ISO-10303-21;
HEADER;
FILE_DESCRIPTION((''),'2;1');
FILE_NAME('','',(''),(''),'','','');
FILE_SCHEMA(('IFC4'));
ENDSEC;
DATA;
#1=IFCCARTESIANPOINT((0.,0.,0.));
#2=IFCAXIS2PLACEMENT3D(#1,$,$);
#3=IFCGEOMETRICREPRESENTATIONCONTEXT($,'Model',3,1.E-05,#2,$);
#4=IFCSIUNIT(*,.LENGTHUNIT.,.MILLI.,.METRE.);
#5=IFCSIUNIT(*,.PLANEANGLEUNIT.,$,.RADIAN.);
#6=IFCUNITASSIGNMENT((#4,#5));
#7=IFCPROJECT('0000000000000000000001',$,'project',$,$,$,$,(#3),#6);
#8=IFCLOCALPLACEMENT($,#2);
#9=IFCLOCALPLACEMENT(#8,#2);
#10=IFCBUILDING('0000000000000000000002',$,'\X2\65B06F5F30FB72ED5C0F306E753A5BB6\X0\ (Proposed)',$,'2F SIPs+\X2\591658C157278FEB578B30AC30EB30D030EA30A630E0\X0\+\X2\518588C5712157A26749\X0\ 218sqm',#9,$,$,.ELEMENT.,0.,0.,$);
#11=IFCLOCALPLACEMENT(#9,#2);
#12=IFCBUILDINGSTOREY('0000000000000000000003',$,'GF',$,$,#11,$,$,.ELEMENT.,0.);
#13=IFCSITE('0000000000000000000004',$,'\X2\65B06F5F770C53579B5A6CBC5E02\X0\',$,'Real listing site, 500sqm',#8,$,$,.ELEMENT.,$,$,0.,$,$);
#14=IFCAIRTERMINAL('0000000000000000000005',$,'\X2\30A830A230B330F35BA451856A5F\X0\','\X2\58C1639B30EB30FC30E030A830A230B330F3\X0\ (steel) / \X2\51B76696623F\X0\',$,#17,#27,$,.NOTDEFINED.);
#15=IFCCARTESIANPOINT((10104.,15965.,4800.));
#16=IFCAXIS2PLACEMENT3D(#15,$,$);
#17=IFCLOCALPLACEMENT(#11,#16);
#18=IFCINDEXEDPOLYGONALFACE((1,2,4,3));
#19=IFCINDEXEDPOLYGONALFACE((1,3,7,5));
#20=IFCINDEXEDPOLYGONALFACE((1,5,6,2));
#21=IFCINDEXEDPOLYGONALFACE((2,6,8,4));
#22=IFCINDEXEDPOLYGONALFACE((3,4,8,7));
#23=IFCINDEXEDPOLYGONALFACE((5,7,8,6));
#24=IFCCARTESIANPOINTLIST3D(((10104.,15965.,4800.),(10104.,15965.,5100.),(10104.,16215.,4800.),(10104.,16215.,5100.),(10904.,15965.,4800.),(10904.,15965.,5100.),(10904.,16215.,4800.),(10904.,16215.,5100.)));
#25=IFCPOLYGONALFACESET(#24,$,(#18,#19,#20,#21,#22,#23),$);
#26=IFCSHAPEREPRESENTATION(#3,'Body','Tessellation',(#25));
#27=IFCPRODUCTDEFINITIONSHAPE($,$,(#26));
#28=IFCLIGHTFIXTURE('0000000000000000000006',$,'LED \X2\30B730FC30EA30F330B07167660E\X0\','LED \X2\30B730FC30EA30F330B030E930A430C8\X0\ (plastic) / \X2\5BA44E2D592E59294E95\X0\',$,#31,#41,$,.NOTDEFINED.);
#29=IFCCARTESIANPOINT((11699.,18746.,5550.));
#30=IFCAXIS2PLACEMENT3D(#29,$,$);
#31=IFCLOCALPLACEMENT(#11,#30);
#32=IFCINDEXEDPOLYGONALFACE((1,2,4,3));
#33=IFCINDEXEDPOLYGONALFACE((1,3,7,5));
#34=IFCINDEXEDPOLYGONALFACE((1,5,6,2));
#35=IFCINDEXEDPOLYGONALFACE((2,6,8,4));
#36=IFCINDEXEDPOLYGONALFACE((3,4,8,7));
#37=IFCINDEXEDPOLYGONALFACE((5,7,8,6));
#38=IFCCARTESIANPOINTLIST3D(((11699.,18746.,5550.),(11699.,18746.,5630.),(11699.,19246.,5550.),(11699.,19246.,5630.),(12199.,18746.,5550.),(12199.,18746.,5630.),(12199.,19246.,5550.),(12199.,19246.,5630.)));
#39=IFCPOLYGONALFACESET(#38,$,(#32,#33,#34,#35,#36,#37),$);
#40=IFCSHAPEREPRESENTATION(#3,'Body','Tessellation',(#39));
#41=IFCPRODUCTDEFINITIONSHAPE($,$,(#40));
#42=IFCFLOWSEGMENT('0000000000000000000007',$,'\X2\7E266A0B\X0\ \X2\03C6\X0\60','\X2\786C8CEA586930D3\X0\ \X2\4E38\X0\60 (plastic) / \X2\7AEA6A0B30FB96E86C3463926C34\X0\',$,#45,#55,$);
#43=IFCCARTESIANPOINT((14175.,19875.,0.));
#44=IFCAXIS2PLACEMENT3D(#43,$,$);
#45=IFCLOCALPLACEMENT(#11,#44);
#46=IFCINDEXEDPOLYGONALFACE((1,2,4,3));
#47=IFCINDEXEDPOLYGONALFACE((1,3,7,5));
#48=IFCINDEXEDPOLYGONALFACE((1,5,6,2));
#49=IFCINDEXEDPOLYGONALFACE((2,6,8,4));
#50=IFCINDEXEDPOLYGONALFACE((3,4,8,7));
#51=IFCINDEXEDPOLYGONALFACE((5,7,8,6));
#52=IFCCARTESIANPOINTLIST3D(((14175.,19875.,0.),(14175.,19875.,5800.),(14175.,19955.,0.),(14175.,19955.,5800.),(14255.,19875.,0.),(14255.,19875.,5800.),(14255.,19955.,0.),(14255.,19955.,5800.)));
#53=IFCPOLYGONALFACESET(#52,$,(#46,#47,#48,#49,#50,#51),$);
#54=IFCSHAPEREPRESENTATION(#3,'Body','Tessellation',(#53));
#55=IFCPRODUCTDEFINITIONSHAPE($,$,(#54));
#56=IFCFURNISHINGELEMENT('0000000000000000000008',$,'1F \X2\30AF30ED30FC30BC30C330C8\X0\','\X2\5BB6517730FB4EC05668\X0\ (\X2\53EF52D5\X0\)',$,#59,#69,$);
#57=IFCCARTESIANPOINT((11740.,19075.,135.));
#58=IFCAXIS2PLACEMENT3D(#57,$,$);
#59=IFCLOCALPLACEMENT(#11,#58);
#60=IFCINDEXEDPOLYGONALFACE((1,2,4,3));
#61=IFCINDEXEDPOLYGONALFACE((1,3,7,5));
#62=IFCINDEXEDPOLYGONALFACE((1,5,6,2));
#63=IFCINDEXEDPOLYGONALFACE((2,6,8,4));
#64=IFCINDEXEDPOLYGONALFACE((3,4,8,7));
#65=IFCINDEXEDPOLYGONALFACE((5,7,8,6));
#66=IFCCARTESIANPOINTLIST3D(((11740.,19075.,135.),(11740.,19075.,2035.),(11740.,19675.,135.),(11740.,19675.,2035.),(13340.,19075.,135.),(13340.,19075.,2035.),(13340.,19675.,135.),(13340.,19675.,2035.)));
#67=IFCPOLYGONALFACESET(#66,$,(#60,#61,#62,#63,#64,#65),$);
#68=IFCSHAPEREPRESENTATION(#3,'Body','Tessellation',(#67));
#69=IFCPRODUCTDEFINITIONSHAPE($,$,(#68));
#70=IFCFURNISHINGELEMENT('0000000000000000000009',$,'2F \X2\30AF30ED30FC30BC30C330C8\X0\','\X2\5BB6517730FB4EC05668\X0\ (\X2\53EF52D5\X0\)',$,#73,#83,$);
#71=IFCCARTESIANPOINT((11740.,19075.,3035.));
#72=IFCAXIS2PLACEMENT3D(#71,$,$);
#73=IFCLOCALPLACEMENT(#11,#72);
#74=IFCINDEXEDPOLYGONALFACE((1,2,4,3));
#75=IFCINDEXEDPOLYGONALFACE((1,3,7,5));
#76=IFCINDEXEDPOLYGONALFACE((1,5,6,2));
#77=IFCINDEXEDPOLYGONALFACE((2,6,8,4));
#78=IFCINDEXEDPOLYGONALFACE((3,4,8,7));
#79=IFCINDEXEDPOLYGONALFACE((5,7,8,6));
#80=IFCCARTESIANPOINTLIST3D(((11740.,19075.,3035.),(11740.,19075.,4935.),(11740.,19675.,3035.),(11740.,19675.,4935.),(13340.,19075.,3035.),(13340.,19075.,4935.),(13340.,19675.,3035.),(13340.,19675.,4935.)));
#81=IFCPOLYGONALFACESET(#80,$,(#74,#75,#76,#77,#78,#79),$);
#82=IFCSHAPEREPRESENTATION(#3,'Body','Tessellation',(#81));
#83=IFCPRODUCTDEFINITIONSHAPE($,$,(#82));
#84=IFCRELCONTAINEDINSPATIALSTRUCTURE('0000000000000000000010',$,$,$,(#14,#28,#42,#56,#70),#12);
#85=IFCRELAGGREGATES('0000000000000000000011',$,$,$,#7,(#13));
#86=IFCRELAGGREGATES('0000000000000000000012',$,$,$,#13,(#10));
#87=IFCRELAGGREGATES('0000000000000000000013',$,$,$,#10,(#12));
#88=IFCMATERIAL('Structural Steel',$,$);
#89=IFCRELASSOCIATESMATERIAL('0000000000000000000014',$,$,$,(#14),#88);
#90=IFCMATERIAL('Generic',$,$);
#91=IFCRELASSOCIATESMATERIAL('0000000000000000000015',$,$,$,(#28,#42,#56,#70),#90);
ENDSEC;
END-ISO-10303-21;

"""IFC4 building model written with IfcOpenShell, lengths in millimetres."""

from ifc_helpers import new_model, si_unit, frame, frame_2d, origin, place, context, project, spatial, rectangle, extrude, material, element, save


model = new_model("IFC4")

# Units and contexts
model_context = context("Model", 3, precision=1e-05, world=origin())
ifc_project = project(units=[si_unit("LENGTHUNIT", "METRE", prefix="MILLI"), si_unit("PLANEANGLEUNIT", "RADIAN")], contexts=[model_context])

# Site, building, storey
site_placement = place(None, origin())
site = spatial("IfcSite", under=ifc_project, at=site_placement, Name="新潟県南魚沼市", ObjectType="Real listing site, 500sqm", CompositionType="ELEMENT", RefElevation=0.0)
building_placement = place(site_placement, origin())
building = spatial("IfcBuilding", under=site, at=building_placement, Name="新潟・狭小の町家 (Proposed)", ObjectType="2F SIPs+外壁圧迫型ガルバリウム+内装無垢杉 218sqm", CompositionType="ELEMENT", ElevationOfRefHeight=0.0, ElevationOfTerrain=0.0)
storey_placement = place(building_placement, origin())
storey = spatial("IfcBuildingStorey", under=building, at=storey_placement, Name="GF", CompositionType="ELEMENT", Elevation=0.0)

# Shared definitions
ifc_material_1 = material(Name="Generic")

# Shared definitions
ifc_material_2 = material(Name="Structural Steel")

# Air terminal
air_terminal_1_placement = place(storey_placement, frame((10104.0, 15965.0, 4800.0)))
element("IfcAirTerminal", 1, at=air_terminal_1_placement, inside=storey, material=ifc_material_2, Name="エアコン室内機", Description="壁掛ルームエアコン (steel) / 冷暖房", PredefinedType="NOTDEFINED", context=model_context, shape_type="SweptSolid", body=[
    extrude(rectangle(XDim=800.0, YDim=250.0, at=frame_2d((400.0, 125.0))), frame((10104.0, 15965.0, 4800.0)), (0.0, 0.0, 1.0), 300.0),
])

# Light fixture
light_fixture_1_placement = place(storey_placement, frame((11699.0, 18746.0, 5550.0)))
element("IfcLightFixture", 2, at=light_fixture_1_placement, inside=storey, material=ifc_material_1, Name="LED シーリング照明", Description="LED シーリングライト (plastic) / 室中央天井", PredefinedType="NOTDEFINED", context=model_context, shape_type="SweptSolid", body=[
    extrude(rectangle(XDim=500.0, YDim=500.0, at=frame_2d((250.0, 250.0))), frame((11699.0, 18746.0, 5550.0)), (0.0, 0.0, 1.0), 80.0),
])

# Flow segment
flow_segment_placement = place(storey_placement, frame((14175.0, 19875.0, 0.0)))
element("IfcFlowSegment", 3, at=flow_segment_placement, inside=storey, material=ifc_material_1, Name="縦樋 φ60", Description="硬質塩ビ 丸60 (plastic) / 竪樋・雨水排水", context=model_context, shape_type="SweptSolid", body=[
    extrude(rectangle(XDim=80.0, YDim=80.0, at=frame_2d((40.0, 40.0))), frame((14175.0, 19875.0, 0.0)), (0.0, 0.0, 1.0), 5800.0),
])

# Furnishing elements
furnishing_1_placement = place(storey_placement, frame((11740.0, 19075.0, 135.0)))
element("IfcFurnishingElement", 4, at=furnishing_1_placement, inside=storey, material=ifc_material_1, Name="1F クローゼット", Description="家具・什器 (可動)", context=model_context, shape_type="SweptSolid", body=[
    extrude(rectangle(XDim=1600.0, YDim=600.0, at=frame_2d((800.0, 300.0))), frame((11740.0, 19075.0, 135.0)), (0.0, 0.0, 1.0), 1900.0),
])
furnishing_2_placement = place(storey_placement, frame((11740.0, 19075.0, 3035.0)))
element("IfcFurnishingElement", 5, at=furnishing_2_placement, inside=storey, material=ifc_material_1, Name="2F クローゼット", Description="家具・什器 (可動)", context=model_context, shape_type="SweptSolid", body=[
    extrude(rectangle(XDim=1600.0, YDim=600.0, at=frame_2d((800.0, 300.0))), frame((11740.0, 19075.0, 3035.0)), (0.0, 0.0, 1.0), 1900.0),
])

save(model, "model.ifc")
